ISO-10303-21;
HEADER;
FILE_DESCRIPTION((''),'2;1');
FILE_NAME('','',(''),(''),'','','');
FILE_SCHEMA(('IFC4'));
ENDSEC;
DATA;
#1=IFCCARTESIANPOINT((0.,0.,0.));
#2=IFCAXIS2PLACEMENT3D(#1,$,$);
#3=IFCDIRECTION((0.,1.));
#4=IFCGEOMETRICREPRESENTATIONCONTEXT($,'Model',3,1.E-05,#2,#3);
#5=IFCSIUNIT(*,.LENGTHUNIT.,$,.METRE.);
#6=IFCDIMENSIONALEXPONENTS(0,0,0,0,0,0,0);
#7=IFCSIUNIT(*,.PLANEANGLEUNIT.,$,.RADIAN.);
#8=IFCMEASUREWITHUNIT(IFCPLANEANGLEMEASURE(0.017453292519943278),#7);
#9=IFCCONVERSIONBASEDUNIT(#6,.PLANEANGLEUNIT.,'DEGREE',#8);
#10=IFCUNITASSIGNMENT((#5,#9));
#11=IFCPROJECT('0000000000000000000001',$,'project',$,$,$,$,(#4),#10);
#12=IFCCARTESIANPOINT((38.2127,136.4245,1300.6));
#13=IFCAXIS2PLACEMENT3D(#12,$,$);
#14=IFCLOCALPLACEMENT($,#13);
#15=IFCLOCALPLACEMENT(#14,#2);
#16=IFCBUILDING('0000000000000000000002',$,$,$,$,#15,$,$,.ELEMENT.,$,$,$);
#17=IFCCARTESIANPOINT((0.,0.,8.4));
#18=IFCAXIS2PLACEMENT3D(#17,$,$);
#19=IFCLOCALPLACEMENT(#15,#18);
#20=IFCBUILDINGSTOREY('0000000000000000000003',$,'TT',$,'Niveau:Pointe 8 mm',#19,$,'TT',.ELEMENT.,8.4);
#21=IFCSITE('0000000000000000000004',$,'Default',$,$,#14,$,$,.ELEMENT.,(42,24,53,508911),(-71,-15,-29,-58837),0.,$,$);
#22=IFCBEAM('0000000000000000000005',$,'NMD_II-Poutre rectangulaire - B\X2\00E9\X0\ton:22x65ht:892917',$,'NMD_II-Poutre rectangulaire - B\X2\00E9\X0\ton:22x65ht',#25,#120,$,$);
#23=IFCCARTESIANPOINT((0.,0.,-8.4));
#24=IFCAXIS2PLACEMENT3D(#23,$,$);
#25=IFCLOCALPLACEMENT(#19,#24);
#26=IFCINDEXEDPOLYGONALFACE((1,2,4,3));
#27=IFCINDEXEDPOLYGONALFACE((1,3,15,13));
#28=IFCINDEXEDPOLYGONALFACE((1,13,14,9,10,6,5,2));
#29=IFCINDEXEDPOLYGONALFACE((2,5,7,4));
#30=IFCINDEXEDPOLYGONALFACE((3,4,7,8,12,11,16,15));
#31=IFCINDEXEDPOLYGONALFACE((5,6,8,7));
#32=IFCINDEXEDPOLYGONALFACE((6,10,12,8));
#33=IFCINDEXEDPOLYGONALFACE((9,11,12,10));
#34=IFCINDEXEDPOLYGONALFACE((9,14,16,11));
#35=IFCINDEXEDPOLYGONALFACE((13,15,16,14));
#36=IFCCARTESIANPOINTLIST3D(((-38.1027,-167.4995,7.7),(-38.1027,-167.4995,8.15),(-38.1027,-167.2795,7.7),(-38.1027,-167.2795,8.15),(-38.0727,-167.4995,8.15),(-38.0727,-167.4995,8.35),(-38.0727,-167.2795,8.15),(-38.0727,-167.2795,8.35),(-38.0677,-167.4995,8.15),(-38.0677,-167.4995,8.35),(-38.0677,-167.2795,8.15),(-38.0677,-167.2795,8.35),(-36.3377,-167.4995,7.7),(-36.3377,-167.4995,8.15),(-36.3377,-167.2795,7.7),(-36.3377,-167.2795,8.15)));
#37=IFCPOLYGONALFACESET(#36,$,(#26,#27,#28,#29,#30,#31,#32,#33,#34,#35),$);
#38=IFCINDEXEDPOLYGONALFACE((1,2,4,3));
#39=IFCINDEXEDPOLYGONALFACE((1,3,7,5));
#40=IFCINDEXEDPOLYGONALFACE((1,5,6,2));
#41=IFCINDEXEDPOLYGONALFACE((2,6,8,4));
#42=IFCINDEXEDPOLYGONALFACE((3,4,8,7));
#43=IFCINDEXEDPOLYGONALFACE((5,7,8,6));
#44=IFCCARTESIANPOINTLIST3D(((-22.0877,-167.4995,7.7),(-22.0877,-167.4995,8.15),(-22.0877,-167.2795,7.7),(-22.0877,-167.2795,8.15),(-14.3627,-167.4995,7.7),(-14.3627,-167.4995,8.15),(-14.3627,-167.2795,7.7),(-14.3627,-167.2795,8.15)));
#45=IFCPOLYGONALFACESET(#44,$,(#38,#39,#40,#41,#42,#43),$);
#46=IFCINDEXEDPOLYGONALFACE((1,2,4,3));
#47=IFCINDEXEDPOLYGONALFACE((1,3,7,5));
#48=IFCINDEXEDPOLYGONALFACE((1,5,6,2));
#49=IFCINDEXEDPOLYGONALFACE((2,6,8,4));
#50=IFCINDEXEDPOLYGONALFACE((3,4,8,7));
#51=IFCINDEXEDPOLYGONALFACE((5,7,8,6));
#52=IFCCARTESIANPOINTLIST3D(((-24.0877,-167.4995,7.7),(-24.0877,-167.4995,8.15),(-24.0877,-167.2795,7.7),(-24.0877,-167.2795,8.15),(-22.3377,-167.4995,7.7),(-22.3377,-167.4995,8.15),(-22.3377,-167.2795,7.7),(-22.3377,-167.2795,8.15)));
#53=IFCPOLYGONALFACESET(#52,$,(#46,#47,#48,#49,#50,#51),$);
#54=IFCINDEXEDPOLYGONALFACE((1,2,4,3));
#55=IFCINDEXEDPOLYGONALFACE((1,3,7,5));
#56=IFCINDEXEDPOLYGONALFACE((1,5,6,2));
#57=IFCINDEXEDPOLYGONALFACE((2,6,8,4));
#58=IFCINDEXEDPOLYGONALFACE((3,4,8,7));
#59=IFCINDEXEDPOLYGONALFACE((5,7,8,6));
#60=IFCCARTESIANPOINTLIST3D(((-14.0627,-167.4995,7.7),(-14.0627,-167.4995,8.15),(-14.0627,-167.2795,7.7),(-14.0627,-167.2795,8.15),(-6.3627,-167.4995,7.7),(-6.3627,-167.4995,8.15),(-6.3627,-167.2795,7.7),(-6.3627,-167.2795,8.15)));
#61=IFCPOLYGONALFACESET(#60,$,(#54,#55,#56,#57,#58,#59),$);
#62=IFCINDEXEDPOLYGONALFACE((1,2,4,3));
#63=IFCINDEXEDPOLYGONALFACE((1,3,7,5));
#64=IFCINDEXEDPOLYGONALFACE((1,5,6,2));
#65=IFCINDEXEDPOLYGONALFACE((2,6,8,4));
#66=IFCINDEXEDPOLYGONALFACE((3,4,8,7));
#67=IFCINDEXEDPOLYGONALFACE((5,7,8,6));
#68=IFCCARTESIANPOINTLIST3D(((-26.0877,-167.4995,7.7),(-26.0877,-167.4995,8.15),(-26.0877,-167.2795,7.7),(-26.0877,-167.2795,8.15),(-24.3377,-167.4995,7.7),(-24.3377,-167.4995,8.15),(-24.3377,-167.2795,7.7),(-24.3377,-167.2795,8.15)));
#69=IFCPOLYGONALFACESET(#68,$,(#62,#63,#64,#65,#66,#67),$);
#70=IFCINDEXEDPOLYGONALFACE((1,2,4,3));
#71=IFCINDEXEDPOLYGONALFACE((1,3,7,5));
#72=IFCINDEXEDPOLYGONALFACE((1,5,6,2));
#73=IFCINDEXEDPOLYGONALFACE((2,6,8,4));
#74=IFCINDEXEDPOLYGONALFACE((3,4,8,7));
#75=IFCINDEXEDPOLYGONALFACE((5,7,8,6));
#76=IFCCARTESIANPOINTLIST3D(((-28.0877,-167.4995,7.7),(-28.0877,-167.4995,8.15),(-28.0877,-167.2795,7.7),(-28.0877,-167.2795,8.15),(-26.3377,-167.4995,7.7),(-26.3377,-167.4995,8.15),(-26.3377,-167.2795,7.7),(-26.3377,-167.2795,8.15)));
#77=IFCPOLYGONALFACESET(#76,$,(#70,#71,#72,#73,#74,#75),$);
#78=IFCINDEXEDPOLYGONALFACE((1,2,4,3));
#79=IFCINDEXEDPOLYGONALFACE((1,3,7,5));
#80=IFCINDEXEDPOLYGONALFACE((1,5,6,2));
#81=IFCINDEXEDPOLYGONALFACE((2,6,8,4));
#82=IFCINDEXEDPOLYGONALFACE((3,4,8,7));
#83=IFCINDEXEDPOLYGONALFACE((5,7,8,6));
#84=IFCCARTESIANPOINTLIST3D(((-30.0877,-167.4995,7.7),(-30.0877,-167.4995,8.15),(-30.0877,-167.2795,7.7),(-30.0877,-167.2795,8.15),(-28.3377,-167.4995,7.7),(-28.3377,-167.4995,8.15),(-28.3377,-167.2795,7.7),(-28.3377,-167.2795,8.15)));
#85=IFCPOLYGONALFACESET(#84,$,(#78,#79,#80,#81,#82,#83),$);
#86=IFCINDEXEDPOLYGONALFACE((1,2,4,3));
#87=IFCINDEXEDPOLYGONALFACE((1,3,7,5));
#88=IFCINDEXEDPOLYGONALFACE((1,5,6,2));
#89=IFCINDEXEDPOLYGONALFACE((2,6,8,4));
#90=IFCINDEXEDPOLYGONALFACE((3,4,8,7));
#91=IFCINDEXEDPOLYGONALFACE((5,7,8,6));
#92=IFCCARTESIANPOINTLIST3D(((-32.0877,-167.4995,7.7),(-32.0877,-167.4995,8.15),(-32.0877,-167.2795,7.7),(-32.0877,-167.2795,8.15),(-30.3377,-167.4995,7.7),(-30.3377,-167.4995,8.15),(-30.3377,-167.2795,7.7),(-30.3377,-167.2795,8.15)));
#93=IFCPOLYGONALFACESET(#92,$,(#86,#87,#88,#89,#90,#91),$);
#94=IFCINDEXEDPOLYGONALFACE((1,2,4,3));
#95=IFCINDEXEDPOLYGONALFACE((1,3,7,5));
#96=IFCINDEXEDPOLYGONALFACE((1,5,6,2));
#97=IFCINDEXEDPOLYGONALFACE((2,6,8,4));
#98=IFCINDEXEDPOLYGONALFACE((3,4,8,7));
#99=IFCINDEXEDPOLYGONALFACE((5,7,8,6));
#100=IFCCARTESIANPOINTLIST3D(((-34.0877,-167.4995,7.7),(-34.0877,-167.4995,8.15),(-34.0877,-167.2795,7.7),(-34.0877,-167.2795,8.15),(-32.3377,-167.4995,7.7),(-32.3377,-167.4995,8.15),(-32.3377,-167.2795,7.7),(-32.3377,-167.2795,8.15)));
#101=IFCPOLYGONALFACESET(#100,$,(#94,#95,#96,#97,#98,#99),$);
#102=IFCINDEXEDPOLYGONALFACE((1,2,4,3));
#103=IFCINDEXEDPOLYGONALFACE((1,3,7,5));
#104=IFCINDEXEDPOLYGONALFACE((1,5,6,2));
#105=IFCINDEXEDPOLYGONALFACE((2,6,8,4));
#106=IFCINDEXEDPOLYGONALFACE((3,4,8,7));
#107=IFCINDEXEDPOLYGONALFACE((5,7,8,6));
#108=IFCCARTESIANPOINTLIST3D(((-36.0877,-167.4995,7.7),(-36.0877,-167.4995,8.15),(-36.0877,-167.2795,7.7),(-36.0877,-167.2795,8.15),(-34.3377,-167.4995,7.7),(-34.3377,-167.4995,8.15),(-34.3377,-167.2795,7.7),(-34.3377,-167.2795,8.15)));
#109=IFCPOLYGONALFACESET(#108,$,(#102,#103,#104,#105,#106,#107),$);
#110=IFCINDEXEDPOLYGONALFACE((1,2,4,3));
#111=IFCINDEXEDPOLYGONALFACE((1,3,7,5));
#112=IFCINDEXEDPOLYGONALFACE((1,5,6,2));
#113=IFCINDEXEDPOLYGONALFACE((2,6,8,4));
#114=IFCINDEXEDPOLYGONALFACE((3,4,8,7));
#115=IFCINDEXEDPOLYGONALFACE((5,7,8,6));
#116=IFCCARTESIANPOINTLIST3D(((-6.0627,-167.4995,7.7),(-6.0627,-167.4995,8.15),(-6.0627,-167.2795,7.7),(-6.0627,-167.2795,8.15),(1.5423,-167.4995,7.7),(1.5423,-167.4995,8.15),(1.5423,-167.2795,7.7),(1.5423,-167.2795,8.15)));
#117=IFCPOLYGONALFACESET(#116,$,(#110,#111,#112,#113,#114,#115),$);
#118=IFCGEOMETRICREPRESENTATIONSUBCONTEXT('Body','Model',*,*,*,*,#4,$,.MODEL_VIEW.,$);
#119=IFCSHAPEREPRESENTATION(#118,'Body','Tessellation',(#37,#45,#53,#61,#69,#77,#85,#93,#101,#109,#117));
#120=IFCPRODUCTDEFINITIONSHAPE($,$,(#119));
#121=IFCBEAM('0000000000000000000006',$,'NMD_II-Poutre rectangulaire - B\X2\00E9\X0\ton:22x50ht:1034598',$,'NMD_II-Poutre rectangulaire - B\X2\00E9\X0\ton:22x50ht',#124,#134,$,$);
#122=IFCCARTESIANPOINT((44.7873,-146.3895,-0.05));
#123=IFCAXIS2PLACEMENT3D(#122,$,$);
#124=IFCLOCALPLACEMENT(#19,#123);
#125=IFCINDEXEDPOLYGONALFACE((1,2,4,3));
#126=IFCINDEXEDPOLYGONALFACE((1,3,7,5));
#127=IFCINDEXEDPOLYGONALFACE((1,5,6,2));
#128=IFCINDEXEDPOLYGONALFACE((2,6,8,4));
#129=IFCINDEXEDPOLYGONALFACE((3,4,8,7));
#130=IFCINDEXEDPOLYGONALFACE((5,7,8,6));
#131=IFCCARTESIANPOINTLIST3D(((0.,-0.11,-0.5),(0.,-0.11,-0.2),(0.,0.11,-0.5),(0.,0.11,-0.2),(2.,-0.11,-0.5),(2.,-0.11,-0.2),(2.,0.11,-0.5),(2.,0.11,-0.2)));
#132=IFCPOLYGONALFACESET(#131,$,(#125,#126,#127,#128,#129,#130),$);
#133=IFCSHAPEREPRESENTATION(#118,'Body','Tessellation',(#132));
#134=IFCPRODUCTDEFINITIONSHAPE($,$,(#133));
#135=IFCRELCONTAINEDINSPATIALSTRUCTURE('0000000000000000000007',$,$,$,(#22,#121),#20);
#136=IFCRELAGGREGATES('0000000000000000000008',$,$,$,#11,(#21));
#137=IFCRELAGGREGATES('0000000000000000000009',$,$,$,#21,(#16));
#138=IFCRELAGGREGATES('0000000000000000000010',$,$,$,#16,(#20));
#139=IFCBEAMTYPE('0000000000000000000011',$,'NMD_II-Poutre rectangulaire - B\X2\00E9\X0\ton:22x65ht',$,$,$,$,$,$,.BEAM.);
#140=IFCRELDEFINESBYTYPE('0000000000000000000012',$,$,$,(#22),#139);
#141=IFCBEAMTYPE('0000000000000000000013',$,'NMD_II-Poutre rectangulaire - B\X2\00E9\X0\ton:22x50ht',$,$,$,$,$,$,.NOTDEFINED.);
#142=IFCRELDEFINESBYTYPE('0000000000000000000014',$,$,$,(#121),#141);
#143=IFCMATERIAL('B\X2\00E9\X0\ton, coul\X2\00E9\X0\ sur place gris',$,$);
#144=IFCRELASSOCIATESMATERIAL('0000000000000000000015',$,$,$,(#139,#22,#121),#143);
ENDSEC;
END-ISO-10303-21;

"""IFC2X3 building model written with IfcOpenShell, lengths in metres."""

from ifc_helpers import new_model, entity, si_unit, converted_unit, direction, frame, frame_2d, origin, place, context, subcontext, project, spatial, polyline, rectangle, outline, extrude, source, transform, mapped, material, type_object, type_shapes, element, save


model = new_model("IFC2X3")

# Units and contexts
model_context = context("Model", 3, precision=1e-05, world=origin(), true_north=direction((0.0, 1.0)))
body_context = subcontext(model_context, "Body", "Model", "MODEL_VIEW")
ifc_project = project(units=[si_unit("LENGTHUNIT", "METRE"), converted_unit("PLANEANGLEUNIT", "DEGREE", entity("IfcPlaneAngleMeasure", 0.017453292519943278), si_unit("PLANEANGLEUNIT", "RADIAN"), dimensions=[0, 0, 0, 0, 0, 0, 0])], contexts=[model_context])

# Site, building, storey
site_placement = place(None, frame((38.2127, 136.4245, 1300.6)))
site = spatial("IfcSite", under=ifc_project, at=site_placement, Name="Default", CompositionType="ELEMENT", RefLatitude=(42, 24, 53, 508911), RefLongitude=(-71, -15, -29, -58837), RefElevation=0.0)
building_placement = place(site_placement, origin())
building = spatial("IfcBuilding", under=site, at=building_placement, CompositionType="ELEMENT")
storey_placement = place(building_placement, frame((0.0, 0.0, 8.4)))
storey = spatial("IfcBuildingStorey", under=building, at=storey_placement, Name="TT", ObjectType="Niveau:Pointe 8 mm", LongName="TT", CompositionType="ELEMENT", Elevation=8.4)

# Beams
ifc_material_1 = material(Name="Béton, coulé sur place gris")
beam_type_1 = type_object("IfcBeamType", Name="NMD_II-Poutre rectangulaire - Béton:22x65ht", PredefinedType="BEAM", material=ifc_material_1)
shared_shape_1 = source(origin(), body_context, "Body", "SweptSolid", [
    extrude(outline(polyline([(-0.3875, -0.4575), (0.0625, -0.4575), (0.0625, -0.4275), (0.2625, -0.4275), (0.2625, -0.4225), (0.0625, -0.4225), (0.0625, 1.3075), (-0.3875, 1.3075), (-0.3875, -0.4575)])), frame((-37.6452, -167.4995, 8.0875), z_axis=(0.0, 1.0, 0.0), x_axis=(0.0, 0.0, 1.0)), (0.0, 0.0, 1.0), 0.22),
    extrude(rectangle(XDim=0.45, YDim=0.22, at=frame_2d((0.0, 0.0), x_axis=(1.0, 0.0))), frame((-22.0877, -167.3895, 7.925), z_axis=(1.0, 0.0, 0.0), x_axis=(0.0, 0.0, 1.0)), (0.0, 0.0, 1.0), 7.725),
    extrude(rectangle(XDim=0.45, YDim=0.22, at=frame_2d((0.0, 0.0), x_axis=(1.0, 0.0))), frame((-24.0877, -167.3895, 7.925), z_axis=(1.0, 0.0, 0.0), x_axis=(0.0, 0.0, 1.0)), (0.0, 0.0, 1.0), 1.75),
    extrude(rectangle(XDim=0.45, YDim=0.22, at=frame_2d((0.0, 0.0), x_axis=(1.0, 0.0))), frame((-14.0627, -167.3895, 7.925), z_axis=(1.0, 0.0, 0.0), x_axis=(0.0, 0.0, 1.0)), (0.0, 0.0, 1.0), 7.7),
    extrude(rectangle(XDim=0.45, YDim=0.22, at=frame_2d((0.0, 0.0), x_axis=(1.0, 0.0))), frame((-26.0877, -167.3895, 7.925), z_axis=(1.0, 0.0, 0.0), x_axis=(0.0, 0.0, 1.0)), (0.0, 0.0, 1.0), 1.75),
    extrude(rectangle(XDim=0.45, YDim=0.22, at=frame_2d((0.0, 0.0), x_axis=(1.0, 0.0))), frame((-28.0877, -167.3895, 7.925), z_axis=(1.0, 0.0, 0.0), x_axis=(0.0, 0.0, 1.0)), (0.0, 0.0, 1.0), 1.75),
    extrude(rectangle(XDim=0.45, YDim=0.22, at=frame_2d((0.0, 0.0), x_axis=(1.0, 0.0))), frame((-30.0877, -167.3895, 7.925), z_axis=(1.0, 0.0, 0.0), x_axis=(0.0, 0.0, 1.0)), (0.0, 0.0, 1.0), 1.75),
    extrude(rectangle(XDim=0.45, YDim=0.22, at=frame_2d((0.0, 0.0), x_axis=(1.0, 0.0))), frame((-32.0877, -167.3895, 7.925), z_axis=(1.0, 0.0, 0.0), x_axis=(0.0, 0.0, 1.0)), (0.0, 0.0, 1.0), 1.75),
    extrude(rectangle(XDim=0.45, YDim=0.22, at=frame_2d((0.0, 0.0), x_axis=(1.0, 0.0))), frame((-34.0877, -167.3895, 7.925), z_axis=(1.0, 0.0, 0.0), x_axis=(0.0, 0.0, 1.0)), (0.0, 0.0, 1.0), 1.75),
    extrude(rectangle(XDim=0.45, YDim=0.22, at=frame_2d((0.0, 0.0), x_axis=(1.0, 0.0))), frame((-36.0877, -167.3895, 7.925), z_axis=(1.0, 0.0, 0.0), x_axis=(0.0, 0.0, 1.0)), (0.0, 0.0, 1.0), 1.75),
    extrude(rectangle(XDim=0.45, YDim=7.605, at=frame_2d((0.0, 0.0), x_axis=(1.0, 0.0))), frame((-2.2602, -167.4995, 7.925), z_axis=(0.0, 1.0, 0.0), x_axis=(0.0, 0.0, 1.0)), (0.0, 0.0, 1.0), 0.22),
])
type_shapes(beam_type_1, [shared_shape_1])
beam_1_placement = place(storey_placement, frame((0.0, 0.0, -8.4)))
element("IfcBeam", 1, at=beam_1_placement, inside=storey, type_object=beam_type_1, material=ifc_material_1, Name="NMD_II-Poutre rectangulaire - Béton:22x65ht:892917", ObjectType="NMD_II-Poutre rectangulaire - Béton:22x65ht", context=body_context, shape_type="MappedRepresentation", body=[
    mapped(shared_shape_1, transform((0.0, 0.0, 0.0), scale=1.0)),
])
beam_type_2 = type_object("IfcBeamType", Name="NMD_II-Poutre rectangulaire - Béton:22x50ht", PredefinedType="NOTDEFINED")
beam_2_placement = place(storey_placement, frame((44.7873, -146.3895, -0.05)))
element("IfcBeam", 2, at=beam_2_placement, inside=storey, type_object=beam_type_2, material=ifc_material_1, Name="NMD_II-Poutre rectangulaire - Béton:22x50ht:1034598", ObjectType="NMD_II-Poutre rectangulaire - Béton:22x50ht", context=body_context, shape_type="SweptSolid", body=[
    extrude(rectangle(XDim=0.3, YDim=0.22, at=frame_2d((0.0, 0.0), x_axis=(1.0, 0.0))), frame((0.0, 0.0, -0.35), z_axis=(1.0, 0.0, 0.0), x_axis=(0.0, 0.0, -1.0)), (0.0, 0.0, 1.0), 2.0),
])

save(model, "model.ifc")
